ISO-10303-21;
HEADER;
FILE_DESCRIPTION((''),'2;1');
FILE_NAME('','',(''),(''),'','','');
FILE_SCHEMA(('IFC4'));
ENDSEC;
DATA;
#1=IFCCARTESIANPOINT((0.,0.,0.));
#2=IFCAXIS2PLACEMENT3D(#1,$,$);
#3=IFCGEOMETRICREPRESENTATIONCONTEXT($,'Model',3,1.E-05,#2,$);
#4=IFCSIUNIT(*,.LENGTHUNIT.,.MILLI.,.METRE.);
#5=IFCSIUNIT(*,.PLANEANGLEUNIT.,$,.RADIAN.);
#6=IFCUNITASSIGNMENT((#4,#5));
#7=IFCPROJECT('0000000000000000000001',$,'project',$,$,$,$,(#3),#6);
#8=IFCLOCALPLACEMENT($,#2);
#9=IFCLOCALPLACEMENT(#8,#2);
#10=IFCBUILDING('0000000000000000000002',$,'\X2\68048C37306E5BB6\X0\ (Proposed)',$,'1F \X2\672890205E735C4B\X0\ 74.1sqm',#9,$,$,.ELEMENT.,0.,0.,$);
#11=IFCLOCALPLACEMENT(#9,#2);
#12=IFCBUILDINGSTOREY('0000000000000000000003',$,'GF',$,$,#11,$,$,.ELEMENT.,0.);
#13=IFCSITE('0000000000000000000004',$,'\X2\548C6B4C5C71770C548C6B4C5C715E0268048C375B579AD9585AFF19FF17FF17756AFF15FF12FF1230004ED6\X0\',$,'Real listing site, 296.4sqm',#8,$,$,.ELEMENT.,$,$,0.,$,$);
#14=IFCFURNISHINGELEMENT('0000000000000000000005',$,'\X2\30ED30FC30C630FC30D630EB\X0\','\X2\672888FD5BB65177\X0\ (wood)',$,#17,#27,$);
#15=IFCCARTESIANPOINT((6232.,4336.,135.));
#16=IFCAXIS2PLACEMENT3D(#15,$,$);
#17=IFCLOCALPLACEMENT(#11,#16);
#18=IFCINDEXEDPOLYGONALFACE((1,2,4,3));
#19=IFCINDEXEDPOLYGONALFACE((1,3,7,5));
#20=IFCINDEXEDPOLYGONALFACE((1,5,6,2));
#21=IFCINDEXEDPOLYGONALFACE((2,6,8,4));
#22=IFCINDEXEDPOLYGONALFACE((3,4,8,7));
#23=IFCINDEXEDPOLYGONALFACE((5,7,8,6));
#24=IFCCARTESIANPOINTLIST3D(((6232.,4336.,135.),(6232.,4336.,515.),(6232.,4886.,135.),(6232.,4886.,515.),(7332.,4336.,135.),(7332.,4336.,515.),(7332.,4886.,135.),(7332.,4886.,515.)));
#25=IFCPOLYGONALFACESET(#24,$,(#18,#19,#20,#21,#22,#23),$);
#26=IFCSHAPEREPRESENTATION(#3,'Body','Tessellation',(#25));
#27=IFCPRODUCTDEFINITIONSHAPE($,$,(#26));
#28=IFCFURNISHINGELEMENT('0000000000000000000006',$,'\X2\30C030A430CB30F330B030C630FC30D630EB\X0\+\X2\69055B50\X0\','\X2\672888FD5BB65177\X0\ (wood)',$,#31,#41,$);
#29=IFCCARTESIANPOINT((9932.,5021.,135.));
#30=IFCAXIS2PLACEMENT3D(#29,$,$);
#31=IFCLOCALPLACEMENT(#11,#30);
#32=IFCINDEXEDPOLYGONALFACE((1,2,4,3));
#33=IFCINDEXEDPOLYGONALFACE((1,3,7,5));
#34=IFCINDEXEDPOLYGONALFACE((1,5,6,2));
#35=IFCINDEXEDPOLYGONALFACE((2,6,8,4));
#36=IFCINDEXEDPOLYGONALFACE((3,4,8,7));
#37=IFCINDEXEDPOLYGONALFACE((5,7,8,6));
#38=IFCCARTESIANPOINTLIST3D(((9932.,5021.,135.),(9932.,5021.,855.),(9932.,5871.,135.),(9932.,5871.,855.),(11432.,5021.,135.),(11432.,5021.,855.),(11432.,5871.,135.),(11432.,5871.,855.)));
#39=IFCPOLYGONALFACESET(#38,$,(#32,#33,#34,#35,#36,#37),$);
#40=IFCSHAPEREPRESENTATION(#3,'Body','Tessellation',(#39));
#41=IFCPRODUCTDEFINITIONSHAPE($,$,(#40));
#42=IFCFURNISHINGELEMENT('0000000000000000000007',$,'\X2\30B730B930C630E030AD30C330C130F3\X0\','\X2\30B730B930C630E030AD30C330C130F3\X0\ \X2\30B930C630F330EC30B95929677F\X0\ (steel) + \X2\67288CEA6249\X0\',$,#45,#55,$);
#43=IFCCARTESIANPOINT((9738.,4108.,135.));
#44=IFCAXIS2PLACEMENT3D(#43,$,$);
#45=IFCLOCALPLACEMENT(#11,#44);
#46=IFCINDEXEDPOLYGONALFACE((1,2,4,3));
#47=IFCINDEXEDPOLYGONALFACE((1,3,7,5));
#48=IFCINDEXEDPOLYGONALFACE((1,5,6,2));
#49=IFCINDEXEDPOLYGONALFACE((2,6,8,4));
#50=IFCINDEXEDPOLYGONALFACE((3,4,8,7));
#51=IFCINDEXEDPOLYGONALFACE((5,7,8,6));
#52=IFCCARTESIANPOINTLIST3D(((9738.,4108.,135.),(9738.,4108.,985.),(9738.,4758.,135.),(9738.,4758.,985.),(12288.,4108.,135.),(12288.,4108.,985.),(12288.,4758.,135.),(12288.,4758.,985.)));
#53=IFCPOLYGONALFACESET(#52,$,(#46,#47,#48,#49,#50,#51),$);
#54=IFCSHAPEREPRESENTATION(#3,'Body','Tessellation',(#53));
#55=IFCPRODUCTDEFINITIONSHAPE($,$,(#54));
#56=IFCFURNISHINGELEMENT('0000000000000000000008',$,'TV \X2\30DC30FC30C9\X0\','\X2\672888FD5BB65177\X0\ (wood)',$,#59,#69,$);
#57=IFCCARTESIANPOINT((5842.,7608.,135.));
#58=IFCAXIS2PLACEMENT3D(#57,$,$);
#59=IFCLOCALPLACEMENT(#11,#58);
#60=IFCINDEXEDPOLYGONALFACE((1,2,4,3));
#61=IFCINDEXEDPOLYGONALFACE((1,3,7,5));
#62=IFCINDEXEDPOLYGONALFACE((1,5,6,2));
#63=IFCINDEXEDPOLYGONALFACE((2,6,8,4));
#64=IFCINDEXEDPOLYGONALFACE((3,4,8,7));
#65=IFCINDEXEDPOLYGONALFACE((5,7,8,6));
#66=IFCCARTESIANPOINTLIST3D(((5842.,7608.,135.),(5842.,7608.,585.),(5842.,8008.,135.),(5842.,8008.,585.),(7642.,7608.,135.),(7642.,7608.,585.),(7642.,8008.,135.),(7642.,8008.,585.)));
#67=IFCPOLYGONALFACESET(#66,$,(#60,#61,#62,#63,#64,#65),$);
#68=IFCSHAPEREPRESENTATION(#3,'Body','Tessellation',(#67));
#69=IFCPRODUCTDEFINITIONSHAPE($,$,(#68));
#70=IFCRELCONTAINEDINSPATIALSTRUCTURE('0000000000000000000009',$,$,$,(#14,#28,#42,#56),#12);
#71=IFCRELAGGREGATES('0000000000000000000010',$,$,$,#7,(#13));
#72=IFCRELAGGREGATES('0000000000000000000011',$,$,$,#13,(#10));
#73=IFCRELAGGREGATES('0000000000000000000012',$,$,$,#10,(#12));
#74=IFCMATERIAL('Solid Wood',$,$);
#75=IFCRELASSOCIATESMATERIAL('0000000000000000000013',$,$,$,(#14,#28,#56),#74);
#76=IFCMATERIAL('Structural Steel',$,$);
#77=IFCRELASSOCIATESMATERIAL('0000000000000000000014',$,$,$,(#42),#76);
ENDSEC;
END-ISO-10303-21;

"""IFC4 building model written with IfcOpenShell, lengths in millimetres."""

from ifc_helpers import new_model, si_unit, frame, frame_2d, origin, place, context, project, spatial, rectangle, extrude, material, element, save


model = new_model("IFC4")

# Units and contexts
model_context = context("Model", 3, precision=1e-05, world=origin())
ifc_project = project(units=[si_unit("LENGTHUNIT", "METRE", prefix="MILLI"), si_unit("PLANEANGLEUNIT", "RADIAN")], contexts=[model_context])

# Site, building, storey
site_placement = place(None, origin())
site = spatial("IfcSite", under=ifc_project, at=site_placement, Name="和歌山県和歌山市栄谷字髙塚９７７番５２２　他", ObjectType="Real listing site, 296.4sqm", CompositionType="ELEMENT", RefElevation=0.0)
building_placement = place(site_placement, origin())
building = spatial("IfcBuilding", under=site, at=building_placement, Name="栄谷の家 (Proposed)", ObjectType="1F 木造平屋 74.1sqm", CompositionType="ELEMENT", ElevationOfRefHeight=0.0, ElevationOfTerrain=0.0)
storey_placement = place(building_placement, origin())
storey = spatial("IfcBuildingStorey", under=building, at=storey_placement, Name="GF", CompositionType="ELEMENT", Elevation=0.0)

# Shared definitions
ifc_material_1 = material(Name="Solid Wood")

# Furnishing elements
furnishing_1_placement = place(storey_placement, frame((6232.0, 4336.0, 135.0)))
element("IfcFurnishingElement", 1, at=furnishing_1_placement, inside=storey, material=ifc_material_1, Name="ローテーブル", Description="木製家具 (wood)", context=model_context, shape_type="SweptSolid", body=[
    extrude(rectangle(XDim=1100.0, YDim=550.0, at=frame_2d((550.0, 275.0))), frame((6232.0, 4336.0, 135.0)), (0.0, 0.0, 1.0), 380.0),
])
furnishing_2_placement = place(storey_placement, frame((9932.0, 5021.0, 135.0)))
element("IfcFurnishingElement", 2, at=furnishing_2_placement, inside=storey, material=ifc_material_1, Name="ダイニングテーブル+椅子", Description="木製家具 (wood)", context=model_context, shape_type="SweptSolid", body=[
    extrude(rectangle(XDim=1500.0, YDim=850.0, at=frame_2d((750.0, 425.0))), frame((9932.0, 5021.0, 135.0)), (0.0, 0.0, 1.0), 720.0),
])
ifc_material_2 = material(Name="Structural Steel")
furnishing_3_placement = place(storey_placement, frame((9738.0, 4108.0, 135.0)))
element("IfcFurnishingElement", 3, at=furnishing_3_placement, inside=storey, material=ifc_material_2, Name="システムキッチン", Description="システムキッチン ステンレス天板 (steel) + 木質扉", context=model_context, shape_type="SweptSolid", body=[
    extrude(rectangle(XDim=2550.0, YDim=650.0, at=frame_2d((1275.0, 325.0))), frame((9738.0, 4108.0, 135.0)), (0.0, 0.0, 1.0), 850.0),
])
furnishing_4_placement = place(storey_placement, frame((5842.0, 7608.0, 135.0)))
element("IfcFurnishingElement", 4, at=furnishing_4_placement, inside=storey, material=ifc_material_1, Name="TV ボード", Description="木製家具 (wood)", context=model_context, shape_type="SweptSolid", body=[
    extrude(rectangle(XDim=1800.0, YDim=400.0, at=frame_2d((900.0, 200.0))), frame((5842.0, 7608.0, 135.0)), (0.0, 0.0, 1.0), 450.0),
])

save(model, "model.ifc")
